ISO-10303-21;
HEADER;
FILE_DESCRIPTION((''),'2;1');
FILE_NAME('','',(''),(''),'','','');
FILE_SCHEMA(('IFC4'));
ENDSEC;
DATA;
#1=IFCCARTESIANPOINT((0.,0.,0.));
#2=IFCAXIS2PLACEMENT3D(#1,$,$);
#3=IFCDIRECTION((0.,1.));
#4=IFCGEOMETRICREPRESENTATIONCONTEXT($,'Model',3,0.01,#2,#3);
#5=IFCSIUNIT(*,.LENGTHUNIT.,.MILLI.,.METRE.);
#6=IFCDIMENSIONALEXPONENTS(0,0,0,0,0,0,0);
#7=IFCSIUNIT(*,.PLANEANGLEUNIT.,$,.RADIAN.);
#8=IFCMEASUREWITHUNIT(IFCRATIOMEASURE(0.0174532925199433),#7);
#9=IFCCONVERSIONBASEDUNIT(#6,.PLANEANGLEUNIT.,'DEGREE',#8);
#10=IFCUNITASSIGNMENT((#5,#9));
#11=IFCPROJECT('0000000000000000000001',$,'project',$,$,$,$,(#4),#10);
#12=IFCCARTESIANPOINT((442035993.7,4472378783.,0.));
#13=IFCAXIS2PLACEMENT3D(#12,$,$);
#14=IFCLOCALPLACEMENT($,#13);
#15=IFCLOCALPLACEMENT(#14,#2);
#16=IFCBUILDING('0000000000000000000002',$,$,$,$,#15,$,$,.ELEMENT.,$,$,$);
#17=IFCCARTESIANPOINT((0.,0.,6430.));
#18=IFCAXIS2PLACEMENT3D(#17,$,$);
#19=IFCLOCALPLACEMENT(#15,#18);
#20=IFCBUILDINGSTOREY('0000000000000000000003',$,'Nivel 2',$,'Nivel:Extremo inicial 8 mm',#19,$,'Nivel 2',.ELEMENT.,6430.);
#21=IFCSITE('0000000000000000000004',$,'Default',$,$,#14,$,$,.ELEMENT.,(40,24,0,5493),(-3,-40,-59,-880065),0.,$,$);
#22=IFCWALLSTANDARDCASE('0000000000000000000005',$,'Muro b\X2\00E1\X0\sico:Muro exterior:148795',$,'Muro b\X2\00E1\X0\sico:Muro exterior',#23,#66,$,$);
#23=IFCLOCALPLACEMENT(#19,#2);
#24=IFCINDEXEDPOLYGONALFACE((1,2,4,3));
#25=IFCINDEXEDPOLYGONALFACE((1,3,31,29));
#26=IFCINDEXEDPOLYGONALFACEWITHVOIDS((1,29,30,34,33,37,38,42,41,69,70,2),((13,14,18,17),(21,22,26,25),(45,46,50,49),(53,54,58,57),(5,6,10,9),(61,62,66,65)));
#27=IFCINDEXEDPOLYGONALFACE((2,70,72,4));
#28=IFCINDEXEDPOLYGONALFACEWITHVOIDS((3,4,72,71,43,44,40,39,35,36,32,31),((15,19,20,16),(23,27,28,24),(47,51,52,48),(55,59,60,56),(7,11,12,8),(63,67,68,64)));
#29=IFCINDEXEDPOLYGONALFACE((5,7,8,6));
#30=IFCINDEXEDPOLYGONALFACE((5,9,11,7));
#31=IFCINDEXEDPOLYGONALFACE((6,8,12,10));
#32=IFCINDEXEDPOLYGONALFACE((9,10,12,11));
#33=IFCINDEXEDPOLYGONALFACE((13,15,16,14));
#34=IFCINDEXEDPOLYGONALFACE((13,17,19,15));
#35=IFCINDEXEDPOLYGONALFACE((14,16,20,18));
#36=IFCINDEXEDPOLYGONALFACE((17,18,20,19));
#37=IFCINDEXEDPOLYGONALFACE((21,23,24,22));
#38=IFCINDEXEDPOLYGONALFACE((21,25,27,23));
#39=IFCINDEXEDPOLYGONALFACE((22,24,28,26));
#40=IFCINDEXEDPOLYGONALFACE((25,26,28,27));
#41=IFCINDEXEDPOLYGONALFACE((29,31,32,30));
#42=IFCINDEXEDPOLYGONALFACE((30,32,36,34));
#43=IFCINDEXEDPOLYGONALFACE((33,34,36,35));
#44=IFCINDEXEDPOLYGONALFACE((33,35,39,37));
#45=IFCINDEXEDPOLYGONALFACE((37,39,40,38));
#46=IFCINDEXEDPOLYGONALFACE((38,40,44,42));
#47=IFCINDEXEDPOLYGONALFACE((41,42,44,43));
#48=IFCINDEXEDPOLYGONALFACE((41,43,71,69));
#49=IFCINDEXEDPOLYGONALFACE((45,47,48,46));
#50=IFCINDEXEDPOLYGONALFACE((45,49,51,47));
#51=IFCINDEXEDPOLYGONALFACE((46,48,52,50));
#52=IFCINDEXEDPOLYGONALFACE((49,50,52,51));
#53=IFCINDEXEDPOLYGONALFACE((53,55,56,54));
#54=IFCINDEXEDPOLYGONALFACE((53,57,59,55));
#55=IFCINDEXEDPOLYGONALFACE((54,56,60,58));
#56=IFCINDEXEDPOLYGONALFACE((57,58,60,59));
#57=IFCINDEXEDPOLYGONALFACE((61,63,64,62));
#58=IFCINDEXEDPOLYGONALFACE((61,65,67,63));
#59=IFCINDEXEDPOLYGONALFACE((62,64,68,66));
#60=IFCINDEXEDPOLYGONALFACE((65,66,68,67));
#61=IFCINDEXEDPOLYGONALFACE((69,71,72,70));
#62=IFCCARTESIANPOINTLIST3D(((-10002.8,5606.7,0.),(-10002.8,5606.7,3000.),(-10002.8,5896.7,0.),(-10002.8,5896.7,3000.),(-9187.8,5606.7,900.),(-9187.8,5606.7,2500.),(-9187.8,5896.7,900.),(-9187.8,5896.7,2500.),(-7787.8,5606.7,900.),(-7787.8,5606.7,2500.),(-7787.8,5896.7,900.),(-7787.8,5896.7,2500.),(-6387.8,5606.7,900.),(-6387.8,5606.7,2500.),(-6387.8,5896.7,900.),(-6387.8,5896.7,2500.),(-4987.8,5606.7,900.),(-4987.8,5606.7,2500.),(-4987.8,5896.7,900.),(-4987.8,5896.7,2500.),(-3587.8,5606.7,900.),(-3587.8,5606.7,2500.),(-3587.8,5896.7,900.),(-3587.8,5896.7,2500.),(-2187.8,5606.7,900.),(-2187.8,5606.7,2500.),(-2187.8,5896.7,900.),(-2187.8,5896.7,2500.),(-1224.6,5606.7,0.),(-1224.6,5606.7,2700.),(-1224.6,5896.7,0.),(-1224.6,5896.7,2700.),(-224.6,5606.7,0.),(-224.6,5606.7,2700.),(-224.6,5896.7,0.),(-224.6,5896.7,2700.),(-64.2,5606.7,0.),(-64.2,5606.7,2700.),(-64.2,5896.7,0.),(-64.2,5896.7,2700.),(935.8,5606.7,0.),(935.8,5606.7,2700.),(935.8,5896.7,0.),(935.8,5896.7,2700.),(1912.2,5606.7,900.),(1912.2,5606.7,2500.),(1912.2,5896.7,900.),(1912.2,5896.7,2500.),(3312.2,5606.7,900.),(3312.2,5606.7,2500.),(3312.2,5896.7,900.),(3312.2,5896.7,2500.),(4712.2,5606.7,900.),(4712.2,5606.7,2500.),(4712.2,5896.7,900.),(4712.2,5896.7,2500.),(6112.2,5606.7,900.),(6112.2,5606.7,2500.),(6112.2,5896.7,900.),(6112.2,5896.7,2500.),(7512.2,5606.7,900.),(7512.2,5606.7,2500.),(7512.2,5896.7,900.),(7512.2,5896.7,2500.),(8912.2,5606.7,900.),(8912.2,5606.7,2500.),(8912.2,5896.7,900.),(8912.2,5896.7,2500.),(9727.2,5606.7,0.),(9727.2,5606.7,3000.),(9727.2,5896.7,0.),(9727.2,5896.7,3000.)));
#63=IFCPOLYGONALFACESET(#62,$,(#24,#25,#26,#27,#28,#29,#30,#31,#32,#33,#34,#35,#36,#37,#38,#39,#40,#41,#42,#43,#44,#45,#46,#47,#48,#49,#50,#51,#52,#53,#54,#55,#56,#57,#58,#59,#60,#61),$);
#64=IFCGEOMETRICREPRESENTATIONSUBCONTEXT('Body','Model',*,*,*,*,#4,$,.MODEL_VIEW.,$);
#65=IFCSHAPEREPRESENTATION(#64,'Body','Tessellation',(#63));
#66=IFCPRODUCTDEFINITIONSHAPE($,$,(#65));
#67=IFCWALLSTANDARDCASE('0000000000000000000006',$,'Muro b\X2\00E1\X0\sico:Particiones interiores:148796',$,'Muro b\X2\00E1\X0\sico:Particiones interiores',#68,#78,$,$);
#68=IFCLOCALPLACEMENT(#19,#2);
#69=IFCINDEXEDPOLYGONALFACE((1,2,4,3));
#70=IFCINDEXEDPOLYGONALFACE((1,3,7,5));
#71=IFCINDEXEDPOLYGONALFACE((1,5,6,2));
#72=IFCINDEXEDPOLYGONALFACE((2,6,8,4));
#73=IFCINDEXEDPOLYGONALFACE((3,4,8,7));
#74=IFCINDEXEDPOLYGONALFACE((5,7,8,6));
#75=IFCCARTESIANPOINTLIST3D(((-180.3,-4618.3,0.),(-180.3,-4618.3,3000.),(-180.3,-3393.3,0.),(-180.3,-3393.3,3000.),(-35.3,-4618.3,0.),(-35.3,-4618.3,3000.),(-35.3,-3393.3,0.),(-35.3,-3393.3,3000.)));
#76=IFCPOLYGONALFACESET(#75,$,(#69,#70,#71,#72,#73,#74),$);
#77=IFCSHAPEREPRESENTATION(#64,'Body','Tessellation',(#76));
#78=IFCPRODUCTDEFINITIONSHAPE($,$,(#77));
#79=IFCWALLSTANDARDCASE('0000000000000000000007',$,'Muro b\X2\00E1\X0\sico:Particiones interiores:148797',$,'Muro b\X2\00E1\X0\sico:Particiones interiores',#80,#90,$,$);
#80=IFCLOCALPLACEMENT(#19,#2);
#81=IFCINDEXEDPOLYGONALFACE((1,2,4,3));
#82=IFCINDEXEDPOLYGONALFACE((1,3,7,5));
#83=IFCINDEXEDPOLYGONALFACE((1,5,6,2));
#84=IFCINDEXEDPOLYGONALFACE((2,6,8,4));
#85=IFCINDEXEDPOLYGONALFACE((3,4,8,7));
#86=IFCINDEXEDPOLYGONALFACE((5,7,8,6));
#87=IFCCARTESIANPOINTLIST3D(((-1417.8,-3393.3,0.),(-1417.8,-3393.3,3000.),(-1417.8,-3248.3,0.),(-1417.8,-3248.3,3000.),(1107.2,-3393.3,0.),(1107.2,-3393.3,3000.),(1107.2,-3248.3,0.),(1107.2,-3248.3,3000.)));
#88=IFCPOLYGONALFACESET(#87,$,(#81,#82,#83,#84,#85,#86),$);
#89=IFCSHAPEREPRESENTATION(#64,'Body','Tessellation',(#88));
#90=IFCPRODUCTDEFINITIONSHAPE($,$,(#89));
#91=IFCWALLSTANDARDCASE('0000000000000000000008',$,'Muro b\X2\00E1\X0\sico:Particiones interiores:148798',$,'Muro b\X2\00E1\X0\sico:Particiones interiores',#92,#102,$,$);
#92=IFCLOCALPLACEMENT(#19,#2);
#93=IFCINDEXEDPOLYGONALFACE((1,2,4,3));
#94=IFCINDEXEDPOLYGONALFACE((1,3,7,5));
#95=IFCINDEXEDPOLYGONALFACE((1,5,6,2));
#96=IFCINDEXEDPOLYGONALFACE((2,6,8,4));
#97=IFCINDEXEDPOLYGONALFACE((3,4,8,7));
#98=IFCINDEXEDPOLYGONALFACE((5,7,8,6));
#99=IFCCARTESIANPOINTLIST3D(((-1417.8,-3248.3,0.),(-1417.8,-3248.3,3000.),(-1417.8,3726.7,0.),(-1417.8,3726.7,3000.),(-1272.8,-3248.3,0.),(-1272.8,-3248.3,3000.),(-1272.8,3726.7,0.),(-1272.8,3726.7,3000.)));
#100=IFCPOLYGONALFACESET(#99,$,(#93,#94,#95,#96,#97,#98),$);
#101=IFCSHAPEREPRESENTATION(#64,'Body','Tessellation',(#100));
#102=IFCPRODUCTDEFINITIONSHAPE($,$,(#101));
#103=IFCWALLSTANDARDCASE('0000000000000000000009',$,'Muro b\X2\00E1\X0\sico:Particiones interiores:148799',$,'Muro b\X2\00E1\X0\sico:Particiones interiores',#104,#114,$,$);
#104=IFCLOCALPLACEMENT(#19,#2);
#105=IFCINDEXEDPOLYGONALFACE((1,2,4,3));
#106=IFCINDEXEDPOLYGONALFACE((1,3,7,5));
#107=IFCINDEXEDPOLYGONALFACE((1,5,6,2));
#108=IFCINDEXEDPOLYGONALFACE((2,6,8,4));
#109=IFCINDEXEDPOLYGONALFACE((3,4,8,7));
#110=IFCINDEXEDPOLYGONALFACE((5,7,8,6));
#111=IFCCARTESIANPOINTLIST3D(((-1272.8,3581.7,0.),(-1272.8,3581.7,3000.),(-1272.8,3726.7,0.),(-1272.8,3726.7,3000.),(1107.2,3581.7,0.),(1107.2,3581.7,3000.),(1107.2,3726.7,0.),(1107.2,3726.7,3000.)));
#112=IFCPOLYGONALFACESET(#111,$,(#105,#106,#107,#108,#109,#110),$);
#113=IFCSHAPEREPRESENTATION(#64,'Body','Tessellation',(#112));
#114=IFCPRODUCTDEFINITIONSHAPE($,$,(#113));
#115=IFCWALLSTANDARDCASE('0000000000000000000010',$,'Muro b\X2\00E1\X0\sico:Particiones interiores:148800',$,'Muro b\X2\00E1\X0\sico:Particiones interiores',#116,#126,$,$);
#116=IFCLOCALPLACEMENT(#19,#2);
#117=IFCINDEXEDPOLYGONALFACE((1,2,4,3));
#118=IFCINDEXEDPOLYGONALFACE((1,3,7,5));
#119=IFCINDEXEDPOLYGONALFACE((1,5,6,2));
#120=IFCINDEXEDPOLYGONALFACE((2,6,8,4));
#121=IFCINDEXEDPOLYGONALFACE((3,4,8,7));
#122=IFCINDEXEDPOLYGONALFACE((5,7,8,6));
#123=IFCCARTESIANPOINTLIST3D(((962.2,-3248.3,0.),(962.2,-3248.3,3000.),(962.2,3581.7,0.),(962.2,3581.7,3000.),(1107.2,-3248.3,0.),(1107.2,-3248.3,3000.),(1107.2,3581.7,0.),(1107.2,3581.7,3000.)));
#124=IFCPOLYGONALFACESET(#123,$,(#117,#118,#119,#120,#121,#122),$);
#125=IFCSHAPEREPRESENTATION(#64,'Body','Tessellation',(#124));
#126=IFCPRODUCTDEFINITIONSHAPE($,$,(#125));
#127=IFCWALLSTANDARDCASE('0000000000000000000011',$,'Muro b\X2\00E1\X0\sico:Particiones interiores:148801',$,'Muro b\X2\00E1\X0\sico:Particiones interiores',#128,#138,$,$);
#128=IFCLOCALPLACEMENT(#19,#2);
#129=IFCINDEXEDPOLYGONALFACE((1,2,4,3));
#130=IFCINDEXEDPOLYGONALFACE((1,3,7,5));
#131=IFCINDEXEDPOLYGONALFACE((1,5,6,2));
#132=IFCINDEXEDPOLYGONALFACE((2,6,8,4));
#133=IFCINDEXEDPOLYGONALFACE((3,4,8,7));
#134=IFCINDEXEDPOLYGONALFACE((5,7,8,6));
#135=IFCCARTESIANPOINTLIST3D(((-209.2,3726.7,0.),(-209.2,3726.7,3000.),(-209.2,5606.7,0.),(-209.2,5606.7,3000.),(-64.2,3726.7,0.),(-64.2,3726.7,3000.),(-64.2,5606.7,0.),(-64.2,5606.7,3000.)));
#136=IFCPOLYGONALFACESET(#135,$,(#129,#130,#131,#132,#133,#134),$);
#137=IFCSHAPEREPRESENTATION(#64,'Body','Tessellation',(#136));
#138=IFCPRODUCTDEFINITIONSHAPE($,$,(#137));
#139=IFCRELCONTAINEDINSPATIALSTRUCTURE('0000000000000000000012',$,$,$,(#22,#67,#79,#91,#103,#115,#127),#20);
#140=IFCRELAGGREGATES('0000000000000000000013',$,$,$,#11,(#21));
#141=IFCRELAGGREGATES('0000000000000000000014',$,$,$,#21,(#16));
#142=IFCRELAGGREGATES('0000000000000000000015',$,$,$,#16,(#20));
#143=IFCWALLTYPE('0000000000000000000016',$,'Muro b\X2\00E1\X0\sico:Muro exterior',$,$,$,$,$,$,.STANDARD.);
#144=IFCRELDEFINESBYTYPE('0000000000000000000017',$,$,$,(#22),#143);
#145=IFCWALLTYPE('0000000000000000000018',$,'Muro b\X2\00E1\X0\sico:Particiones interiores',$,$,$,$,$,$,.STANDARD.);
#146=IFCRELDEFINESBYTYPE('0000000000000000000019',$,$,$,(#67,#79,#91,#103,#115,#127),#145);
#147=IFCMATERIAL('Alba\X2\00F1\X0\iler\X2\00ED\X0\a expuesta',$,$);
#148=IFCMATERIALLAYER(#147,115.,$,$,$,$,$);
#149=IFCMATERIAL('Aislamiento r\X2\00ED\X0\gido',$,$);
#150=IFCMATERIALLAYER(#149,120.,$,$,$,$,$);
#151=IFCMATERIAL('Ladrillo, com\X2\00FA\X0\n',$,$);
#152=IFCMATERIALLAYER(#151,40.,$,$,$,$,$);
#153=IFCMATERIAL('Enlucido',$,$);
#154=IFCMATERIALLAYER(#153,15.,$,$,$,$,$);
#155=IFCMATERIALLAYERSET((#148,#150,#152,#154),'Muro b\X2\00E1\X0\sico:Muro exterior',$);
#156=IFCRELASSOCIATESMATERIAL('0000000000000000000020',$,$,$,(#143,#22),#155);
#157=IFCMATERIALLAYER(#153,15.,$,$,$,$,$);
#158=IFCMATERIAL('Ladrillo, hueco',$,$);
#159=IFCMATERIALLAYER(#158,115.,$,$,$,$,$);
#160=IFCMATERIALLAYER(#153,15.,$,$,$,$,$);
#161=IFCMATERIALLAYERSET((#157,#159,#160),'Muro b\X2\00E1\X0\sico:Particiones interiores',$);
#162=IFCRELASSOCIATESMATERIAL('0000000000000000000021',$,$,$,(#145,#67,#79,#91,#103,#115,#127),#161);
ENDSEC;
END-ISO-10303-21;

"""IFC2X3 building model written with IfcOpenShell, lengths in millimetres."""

from ifc_helpers import new_model, entity, si_unit, converted_unit, direction, frame, frame_2d, origin, place, context, subcontext, project, spatial, polyline, rectangle, extrude, clip, bounded_halfspace, material, layer, layer_set, layer_usage, type_object, element, save


model = new_model("IFC2X3")

# Units and contexts
model_context = context("Model", 3, precision=0.01, world=origin(), true_north=direction((0.0, 1.0)))
body_context = subcontext(model_context, "Body", "Model", "MODEL_VIEW")
ifc_project = project(units=[si_unit("LENGTHUNIT", "METRE", prefix="MILLI"), converted_unit("PLANEANGLEUNIT", "DEGREE", entity("IfcRatioMeasure", 0.0174532925199433), si_unit("PLANEANGLEUNIT", "RADIAN"), dimensions=[0, 0, 0, 0, 0, 0, 0])], contexts=[model_context])

# Site, building, storey
site_placement = place(None, frame((442035993.7, 4472378783.0, 0.0)))
site = spatial("IfcSite", under=ifc_project, at=site_placement, Name="Default", CompositionType="ELEMENT", RefLatitude=(40, 24, 0, 5493), RefLongitude=(-3, -40, -59, -880065), RefElevation=0.0)
building_placement = place(site_placement, origin())
building = spatial("IfcBuilding", under=site, at=building_placement, CompositionType="ELEMENT")
storey_placement = place(building_placement, frame((0.0, 0.0, 6430.0)))
storey = spatial("IfcBuildingStorey", under=building, at=storey_placement, Name="Nivel 2", ObjectType="Nivel:Extremo inicial 8 mm", LongName="Nivel 2", CompositionType="ELEMENT", Elevation=6430.0)

# Shared definitions
ifc_material_1 = material(Name="Enlucido")

# Shared definitions
ifc_material_2 = material(Name="Albañilería expuesta")
ifc_layer_1 = layer(ifc_material_2, 115.0)
ifc_material_3 = material(Name="Aislamiento rígido")
ifc_layer_2 = layer(ifc_material_3, 120.0)
ifc_material_4 = material(Name="Ladrillo, común")
ifc_layer_3 = layer(ifc_material_4, 40.0)
ifc_layer_4 = layer(ifc_material_1, 15.0)
ifc_layer_set_1 = layer_set([ifc_layer_1, ifc_layer_2, ifc_layer_3, ifc_layer_4], Name="Muro básico:Muro exterior")
wall_type_1 = type_object("IfcWallType", Name="Muro básico:Muro exterior", PredefinedType="STANDARD", material=ifc_layer_set_1)

# Wall, openings
ifc_layer_usage_1 = layer_usage(ifc_layer_set_1, "AXIS2", "NEGATIVE", 145.0)
wall_1_placement = place(storey_placement, frame((-10002.8, 5751.7, 0.0)))
wall_1 = element("IfcWallStandardCase", 1, at=wall_1_placement, inside=storey, type_object=wall_type_1, material=ifc_layer_usage_1, Name="Muro básico:Muro exterior:148795", ObjectType="Muro básico:Muro exterior", context=body_context, shape_type="Clipping", body=[
    clip(extrude(rectangle(XDim=19730.0, YDim=290.0, at=frame_2d((9865.0, 0.0), x_axis=(-1.0, 0.0))), origin(), (0.0, 0.0, 1.0), 3000.0), bounded_halfspace(frame((0.0, -145.0, 3000.0), z_axis=(0.0, 0.0, 1.0), x_axis=(0.0, 1.0, 0.0)), False, frame((0.0, -145.0, 3000.0), z_axis=(0.0, 0.0, 1.0), x_axis=(0.0, 1.0, 0.0)), polyline([(0.0, 0.0), (0.0, -9793.6), (0.0, -9938.6), (0.0, -19730.0), (290.0, -19730.0), (290.0, 0.0), (0.0, 0.0)]))),
])
opening_1_placement = place(wall_1_placement, origin())
element("IfcOpeningElement", 2, at=opening_1_placement, cuts=wall_1, ObjectType="Opening", context=body_context, shape_type="SweptSolid", body=[
    extrude(rectangle(XDim=2700.0, YDim=1000.0, at=frame_2d((0.0, 0.0), x_axis=(1.0, 0.0))), frame((10438.6, -1669.0, 1350.0), z_axis=(0.0, 1.0, 0.0), x_axis=(0.0, 0.0, 1.0)), (0.0, 0.0, 1.0), 3048.0),
])
opening_2_placement = place(wall_1_placement, origin())
element("IfcOpeningElement", 3, at=opening_2_placement, cuts=wall_1, ObjectType="Opening", context=body_context, shape_type="SweptSolid", body=[
    extrude(rectangle(XDim=2700.0, YDim=1000.0, at=frame_2d((0.0, 0.0), x_axis=(1.0, 0.0))), frame((9278.2, -1669.0, 1350.0), z_axis=(0.0, 1.0, 0.0), x_axis=(0.0, 0.0, 1.0)), (0.0, 0.0, 1.0), 3048.0),
])
opening_3_placement = place(wall_1_placement, frame((18915.0, 145.0, 900.0)))
element("IfcOpeningElement", 4, at=opening_3_placement, cuts=wall_1, ObjectType="Opening", context=body_context, shape_type="SweptSolid", body=[
    extrude(rectangle(XDim=1600.0, YDim=1400.0, at=frame_2d((800.0, 700.0), x_axis=(1.0, 0.0))), frame((0.0, 0.0, 0.0), z_axis=(0.0, -1.0, 0.0), x_axis=(0.0, 0.0, 1.0)), (0.0, 0.0, 1.0), 290.0),
])
opening_4_placement = place(wall_1_placement, frame((16115.0, 145.0, 900.0)))
element("IfcOpeningElement", 5, at=opening_4_placement, cuts=wall_1, ObjectType="Opening", context=body_context, shape_type="SweptSolid", body=[
    extrude(rectangle(XDim=1600.0, YDim=1400.0, at=frame_2d((800.0, 700.0), x_axis=(1.0, 0.0))), frame((0.0, 0.0, 0.0), z_axis=(0.0, -1.0, 0.0), x_axis=(0.0, 0.0, 1.0)), (0.0, 0.0, 1.0), 290.0),
])
opening_5_placement = place(wall_1_placement, frame((13315.0, 145.0, 900.0)))
element("IfcOpeningElement", 6, at=opening_5_placement, cuts=wall_1, ObjectType="Opening", context=body_context, shape_type="SweptSolid", body=[
    extrude(rectangle(XDim=1600.0, YDim=1400.0, at=frame_2d((800.0, 700.0), x_axis=(1.0, 0.0))), frame((0.0, 0.0, 0.0), z_axis=(0.0, -1.0, 0.0), x_axis=(0.0, 0.0, 1.0)), (0.0, 0.0, 1.0), 290.0),
])
opening_6_placement = place(wall_1_placement, frame((7815.0, 145.0, 900.0)))
element("IfcOpeningElement", 7, at=opening_6_placement, cuts=wall_1, ObjectType="Opening", context=body_context, shape_type="SweptSolid", body=[
    extrude(rectangle(XDim=1600.0, YDim=1400.0, at=frame_2d((800.0, 700.0), x_axis=(1.0, 0.0))), frame((0.0, 0.0, 0.0), z_axis=(0.0, -1.0, 0.0), x_axis=(0.0, 0.0, 1.0)), (0.0, 0.0, 1.0), 290.0),
])
opening_7_placement = place(wall_1_placement, frame((5015.0, 145.0, 900.0)))
element("IfcOpeningElement", 8, at=opening_7_placement, cuts=wall_1, ObjectType="Opening", context=body_context, shape_type="SweptSolid", body=[
    extrude(rectangle(XDim=1600.0, YDim=1400.0, at=frame_2d((800.0, 700.0), x_axis=(1.0, 0.0))), frame((0.0, 0.0, 0.0), z_axis=(0.0, -1.0, 0.0), x_axis=(0.0, 0.0, 1.0)), (0.0, 0.0, 1.0), 290.0),
])
opening_8_placement = place(wall_1_placement, frame((2215.0, 145.0, 900.0)))
element("IfcOpeningElement", 9, at=opening_8_placement, cuts=wall_1, ObjectType="Opening", context=body_context, shape_type="SweptSolid", body=[
    extrude(rectangle(XDim=1600.0, YDim=1400.0, at=frame_2d((800.0, 700.0), x_axis=(1.0, 0.0))), frame((0.0, 0.0, 0.0), z_axis=(0.0, -1.0, 0.0), x_axis=(0.0, 0.0, 1.0)), (0.0, 0.0, 1.0), 290.0),
])

# Walls
ifc_layer_5 = layer(ifc_material_1, 15.0)
ifc_material_5 = material(Name="Ladrillo, hueco")
ifc_layer_6 = layer(ifc_material_5, 115.0)
ifc_layer_7 = layer(ifc_material_1, 15.0)
ifc_layer_set_2 = layer_set([ifc_layer_5, ifc_layer_6, ifc_layer_7], Name="Muro básico:Particiones interiores")
ifc_layer_usage_2 = layer_usage(ifc_layer_set_2, "AXIS2", "NEGATIVE", 72.5)
wall_type_2 = type_object("IfcWallType", Name="Muro básico:Particiones interiores", PredefinedType="STANDARD", material=ifc_layer_set_2)
wall_2_placement = place(storey_placement, frame((-107.8, -4618.3, 0.0), z_axis=(0.0, 0.0, 1.0), x_axis=(0.0, 1.0, 0.0)))
element("IfcWallStandardCase", 10, at=wall_2_placement, inside=storey, type_object=wall_type_2, material=ifc_layer_usage_2, Name="Muro básico:Particiones interiores:148796", ObjectType="Muro básico:Particiones interiores", context=body_context, shape_type="SweptSolid", body=[
    extrude(rectangle(XDim=1225.0, YDim=145.0, at=frame_2d((612.5, 0.0), x_axis=(-1.0, 0.0))), origin(), (0.0, 0.0, 1.0), 3000.0),
])
ifc_layer_usage_3 = layer_usage(ifc_layer_set_2, "AXIS2", "NEGATIVE", 72.5)
wall_3_placement = place(storey_placement, frame((1107.2, -3320.8, 0.0), z_axis=(0.0, 0.0, 1.0), x_axis=(-1.0, 0.0, 0.0)))
element("IfcWallStandardCase", 11, at=wall_3_placement, inside=storey, type_object=wall_type_2, material=ifc_layer_usage_3, Name="Muro básico:Particiones interiores:148797", ObjectType="Muro básico:Particiones interiores", context=body_context, shape_type="SweptSolid", body=[
    extrude(rectangle(XDim=2525.0, YDim=145.0, at=frame_2d((1262.5, 0.0), x_axis=(-1.0, 0.0))), origin(), (0.0, 0.0, 1.0), 3000.0),
])
ifc_layer_usage_4 = layer_usage(ifc_layer_set_2, "AXIS2", "NEGATIVE", 72.5)
wall_4_placement = place(storey_placement, frame((-1345.3, -3248.3, 0.0), z_axis=(0.0, 0.0, 1.0), x_axis=(0.0, 1.0, 0.0)))
element("IfcWallStandardCase", 12, at=wall_4_placement, inside=storey, type_object=wall_type_2, material=ifc_layer_usage_4, Name="Muro básico:Particiones interiores:148798", ObjectType="Muro básico:Particiones interiores", context=body_context, shape_type="SweptSolid", body=[
    extrude(rectangle(XDim=6975.0, YDim=145.0, at=frame_2d((3487.5, 0.0), x_axis=(-1.0, 0.0))), origin(), (0.0, 0.0, 1.0), 3000.0),
])
ifc_layer_usage_5 = layer_usage(ifc_layer_set_2, "AXIS2", "NEGATIVE", 72.5)
wall_5_placement = place(storey_placement, frame((-1272.8, 3654.2, 0.0)))
element("IfcWallStandardCase", 13, at=wall_5_placement, inside=storey, type_object=wall_type_2, material=ifc_layer_usage_5, Name="Muro básico:Particiones interiores:148799", ObjectType="Muro básico:Particiones interiores", context=body_context, shape_type="SweptSolid", body=[
    extrude(rectangle(XDim=2380.0, YDim=145.0, at=frame_2d((1190.0, 0.0), x_axis=(-1.0, 0.0))), origin(), (0.0, 0.0, 1.0), 3000.0),
])
ifc_layer_usage_6 = layer_usage(ifc_layer_set_2, "AXIS2", "NEGATIVE", 72.5)
wall_6_placement = place(storey_placement, frame((1034.7, 3581.7, 0.0), z_axis=(0.0, 0.0, 1.0), x_axis=(0.0, -1.0, 0.0)))
element("IfcWallStandardCase", 14, at=wall_6_placement, inside=storey, type_object=wall_type_2, material=ifc_layer_usage_6, Name="Muro básico:Particiones interiores:148800", ObjectType="Muro básico:Particiones interiores", context=body_context, shape_type="SweptSolid", body=[
    extrude(rectangle(XDim=6830.0, YDim=145.0, at=frame_2d((3415.0, 0.0), x_axis=(-1.0, 0.0))), origin(), (0.0, 0.0, 1.0), 3000.0),
])
ifc_layer_usage_7 = layer_usage(ifc_layer_set_2, "AXIS2", "NEGATIVE", 72.5)
wall_7_placement = place(storey_placement, frame((-136.7, 3726.7, 0.0), z_axis=(0.0, 0.0, 1.0), x_axis=(0.0, 1.0, 0.0)))
element("IfcWallStandardCase", 15, at=wall_7_placement, inside=storey, type_object=wall_type_2, material=ifc_layer_usage_7, Name="Muro básico:Particiones interiores:148801", ObjectType="Muro básico:Particiones interiores", context=body_context, shape_type="SweptSolid", body=[
    extrude(rectangle(XDim=1880.0, YDim=145.0, at=frame_2d((940.0, 0.0), x_axis=(-1.0, 0.0))), origin(), (0.0, 0.0, 1.0), 3000.0),
])

save(model, "model.ifc")
